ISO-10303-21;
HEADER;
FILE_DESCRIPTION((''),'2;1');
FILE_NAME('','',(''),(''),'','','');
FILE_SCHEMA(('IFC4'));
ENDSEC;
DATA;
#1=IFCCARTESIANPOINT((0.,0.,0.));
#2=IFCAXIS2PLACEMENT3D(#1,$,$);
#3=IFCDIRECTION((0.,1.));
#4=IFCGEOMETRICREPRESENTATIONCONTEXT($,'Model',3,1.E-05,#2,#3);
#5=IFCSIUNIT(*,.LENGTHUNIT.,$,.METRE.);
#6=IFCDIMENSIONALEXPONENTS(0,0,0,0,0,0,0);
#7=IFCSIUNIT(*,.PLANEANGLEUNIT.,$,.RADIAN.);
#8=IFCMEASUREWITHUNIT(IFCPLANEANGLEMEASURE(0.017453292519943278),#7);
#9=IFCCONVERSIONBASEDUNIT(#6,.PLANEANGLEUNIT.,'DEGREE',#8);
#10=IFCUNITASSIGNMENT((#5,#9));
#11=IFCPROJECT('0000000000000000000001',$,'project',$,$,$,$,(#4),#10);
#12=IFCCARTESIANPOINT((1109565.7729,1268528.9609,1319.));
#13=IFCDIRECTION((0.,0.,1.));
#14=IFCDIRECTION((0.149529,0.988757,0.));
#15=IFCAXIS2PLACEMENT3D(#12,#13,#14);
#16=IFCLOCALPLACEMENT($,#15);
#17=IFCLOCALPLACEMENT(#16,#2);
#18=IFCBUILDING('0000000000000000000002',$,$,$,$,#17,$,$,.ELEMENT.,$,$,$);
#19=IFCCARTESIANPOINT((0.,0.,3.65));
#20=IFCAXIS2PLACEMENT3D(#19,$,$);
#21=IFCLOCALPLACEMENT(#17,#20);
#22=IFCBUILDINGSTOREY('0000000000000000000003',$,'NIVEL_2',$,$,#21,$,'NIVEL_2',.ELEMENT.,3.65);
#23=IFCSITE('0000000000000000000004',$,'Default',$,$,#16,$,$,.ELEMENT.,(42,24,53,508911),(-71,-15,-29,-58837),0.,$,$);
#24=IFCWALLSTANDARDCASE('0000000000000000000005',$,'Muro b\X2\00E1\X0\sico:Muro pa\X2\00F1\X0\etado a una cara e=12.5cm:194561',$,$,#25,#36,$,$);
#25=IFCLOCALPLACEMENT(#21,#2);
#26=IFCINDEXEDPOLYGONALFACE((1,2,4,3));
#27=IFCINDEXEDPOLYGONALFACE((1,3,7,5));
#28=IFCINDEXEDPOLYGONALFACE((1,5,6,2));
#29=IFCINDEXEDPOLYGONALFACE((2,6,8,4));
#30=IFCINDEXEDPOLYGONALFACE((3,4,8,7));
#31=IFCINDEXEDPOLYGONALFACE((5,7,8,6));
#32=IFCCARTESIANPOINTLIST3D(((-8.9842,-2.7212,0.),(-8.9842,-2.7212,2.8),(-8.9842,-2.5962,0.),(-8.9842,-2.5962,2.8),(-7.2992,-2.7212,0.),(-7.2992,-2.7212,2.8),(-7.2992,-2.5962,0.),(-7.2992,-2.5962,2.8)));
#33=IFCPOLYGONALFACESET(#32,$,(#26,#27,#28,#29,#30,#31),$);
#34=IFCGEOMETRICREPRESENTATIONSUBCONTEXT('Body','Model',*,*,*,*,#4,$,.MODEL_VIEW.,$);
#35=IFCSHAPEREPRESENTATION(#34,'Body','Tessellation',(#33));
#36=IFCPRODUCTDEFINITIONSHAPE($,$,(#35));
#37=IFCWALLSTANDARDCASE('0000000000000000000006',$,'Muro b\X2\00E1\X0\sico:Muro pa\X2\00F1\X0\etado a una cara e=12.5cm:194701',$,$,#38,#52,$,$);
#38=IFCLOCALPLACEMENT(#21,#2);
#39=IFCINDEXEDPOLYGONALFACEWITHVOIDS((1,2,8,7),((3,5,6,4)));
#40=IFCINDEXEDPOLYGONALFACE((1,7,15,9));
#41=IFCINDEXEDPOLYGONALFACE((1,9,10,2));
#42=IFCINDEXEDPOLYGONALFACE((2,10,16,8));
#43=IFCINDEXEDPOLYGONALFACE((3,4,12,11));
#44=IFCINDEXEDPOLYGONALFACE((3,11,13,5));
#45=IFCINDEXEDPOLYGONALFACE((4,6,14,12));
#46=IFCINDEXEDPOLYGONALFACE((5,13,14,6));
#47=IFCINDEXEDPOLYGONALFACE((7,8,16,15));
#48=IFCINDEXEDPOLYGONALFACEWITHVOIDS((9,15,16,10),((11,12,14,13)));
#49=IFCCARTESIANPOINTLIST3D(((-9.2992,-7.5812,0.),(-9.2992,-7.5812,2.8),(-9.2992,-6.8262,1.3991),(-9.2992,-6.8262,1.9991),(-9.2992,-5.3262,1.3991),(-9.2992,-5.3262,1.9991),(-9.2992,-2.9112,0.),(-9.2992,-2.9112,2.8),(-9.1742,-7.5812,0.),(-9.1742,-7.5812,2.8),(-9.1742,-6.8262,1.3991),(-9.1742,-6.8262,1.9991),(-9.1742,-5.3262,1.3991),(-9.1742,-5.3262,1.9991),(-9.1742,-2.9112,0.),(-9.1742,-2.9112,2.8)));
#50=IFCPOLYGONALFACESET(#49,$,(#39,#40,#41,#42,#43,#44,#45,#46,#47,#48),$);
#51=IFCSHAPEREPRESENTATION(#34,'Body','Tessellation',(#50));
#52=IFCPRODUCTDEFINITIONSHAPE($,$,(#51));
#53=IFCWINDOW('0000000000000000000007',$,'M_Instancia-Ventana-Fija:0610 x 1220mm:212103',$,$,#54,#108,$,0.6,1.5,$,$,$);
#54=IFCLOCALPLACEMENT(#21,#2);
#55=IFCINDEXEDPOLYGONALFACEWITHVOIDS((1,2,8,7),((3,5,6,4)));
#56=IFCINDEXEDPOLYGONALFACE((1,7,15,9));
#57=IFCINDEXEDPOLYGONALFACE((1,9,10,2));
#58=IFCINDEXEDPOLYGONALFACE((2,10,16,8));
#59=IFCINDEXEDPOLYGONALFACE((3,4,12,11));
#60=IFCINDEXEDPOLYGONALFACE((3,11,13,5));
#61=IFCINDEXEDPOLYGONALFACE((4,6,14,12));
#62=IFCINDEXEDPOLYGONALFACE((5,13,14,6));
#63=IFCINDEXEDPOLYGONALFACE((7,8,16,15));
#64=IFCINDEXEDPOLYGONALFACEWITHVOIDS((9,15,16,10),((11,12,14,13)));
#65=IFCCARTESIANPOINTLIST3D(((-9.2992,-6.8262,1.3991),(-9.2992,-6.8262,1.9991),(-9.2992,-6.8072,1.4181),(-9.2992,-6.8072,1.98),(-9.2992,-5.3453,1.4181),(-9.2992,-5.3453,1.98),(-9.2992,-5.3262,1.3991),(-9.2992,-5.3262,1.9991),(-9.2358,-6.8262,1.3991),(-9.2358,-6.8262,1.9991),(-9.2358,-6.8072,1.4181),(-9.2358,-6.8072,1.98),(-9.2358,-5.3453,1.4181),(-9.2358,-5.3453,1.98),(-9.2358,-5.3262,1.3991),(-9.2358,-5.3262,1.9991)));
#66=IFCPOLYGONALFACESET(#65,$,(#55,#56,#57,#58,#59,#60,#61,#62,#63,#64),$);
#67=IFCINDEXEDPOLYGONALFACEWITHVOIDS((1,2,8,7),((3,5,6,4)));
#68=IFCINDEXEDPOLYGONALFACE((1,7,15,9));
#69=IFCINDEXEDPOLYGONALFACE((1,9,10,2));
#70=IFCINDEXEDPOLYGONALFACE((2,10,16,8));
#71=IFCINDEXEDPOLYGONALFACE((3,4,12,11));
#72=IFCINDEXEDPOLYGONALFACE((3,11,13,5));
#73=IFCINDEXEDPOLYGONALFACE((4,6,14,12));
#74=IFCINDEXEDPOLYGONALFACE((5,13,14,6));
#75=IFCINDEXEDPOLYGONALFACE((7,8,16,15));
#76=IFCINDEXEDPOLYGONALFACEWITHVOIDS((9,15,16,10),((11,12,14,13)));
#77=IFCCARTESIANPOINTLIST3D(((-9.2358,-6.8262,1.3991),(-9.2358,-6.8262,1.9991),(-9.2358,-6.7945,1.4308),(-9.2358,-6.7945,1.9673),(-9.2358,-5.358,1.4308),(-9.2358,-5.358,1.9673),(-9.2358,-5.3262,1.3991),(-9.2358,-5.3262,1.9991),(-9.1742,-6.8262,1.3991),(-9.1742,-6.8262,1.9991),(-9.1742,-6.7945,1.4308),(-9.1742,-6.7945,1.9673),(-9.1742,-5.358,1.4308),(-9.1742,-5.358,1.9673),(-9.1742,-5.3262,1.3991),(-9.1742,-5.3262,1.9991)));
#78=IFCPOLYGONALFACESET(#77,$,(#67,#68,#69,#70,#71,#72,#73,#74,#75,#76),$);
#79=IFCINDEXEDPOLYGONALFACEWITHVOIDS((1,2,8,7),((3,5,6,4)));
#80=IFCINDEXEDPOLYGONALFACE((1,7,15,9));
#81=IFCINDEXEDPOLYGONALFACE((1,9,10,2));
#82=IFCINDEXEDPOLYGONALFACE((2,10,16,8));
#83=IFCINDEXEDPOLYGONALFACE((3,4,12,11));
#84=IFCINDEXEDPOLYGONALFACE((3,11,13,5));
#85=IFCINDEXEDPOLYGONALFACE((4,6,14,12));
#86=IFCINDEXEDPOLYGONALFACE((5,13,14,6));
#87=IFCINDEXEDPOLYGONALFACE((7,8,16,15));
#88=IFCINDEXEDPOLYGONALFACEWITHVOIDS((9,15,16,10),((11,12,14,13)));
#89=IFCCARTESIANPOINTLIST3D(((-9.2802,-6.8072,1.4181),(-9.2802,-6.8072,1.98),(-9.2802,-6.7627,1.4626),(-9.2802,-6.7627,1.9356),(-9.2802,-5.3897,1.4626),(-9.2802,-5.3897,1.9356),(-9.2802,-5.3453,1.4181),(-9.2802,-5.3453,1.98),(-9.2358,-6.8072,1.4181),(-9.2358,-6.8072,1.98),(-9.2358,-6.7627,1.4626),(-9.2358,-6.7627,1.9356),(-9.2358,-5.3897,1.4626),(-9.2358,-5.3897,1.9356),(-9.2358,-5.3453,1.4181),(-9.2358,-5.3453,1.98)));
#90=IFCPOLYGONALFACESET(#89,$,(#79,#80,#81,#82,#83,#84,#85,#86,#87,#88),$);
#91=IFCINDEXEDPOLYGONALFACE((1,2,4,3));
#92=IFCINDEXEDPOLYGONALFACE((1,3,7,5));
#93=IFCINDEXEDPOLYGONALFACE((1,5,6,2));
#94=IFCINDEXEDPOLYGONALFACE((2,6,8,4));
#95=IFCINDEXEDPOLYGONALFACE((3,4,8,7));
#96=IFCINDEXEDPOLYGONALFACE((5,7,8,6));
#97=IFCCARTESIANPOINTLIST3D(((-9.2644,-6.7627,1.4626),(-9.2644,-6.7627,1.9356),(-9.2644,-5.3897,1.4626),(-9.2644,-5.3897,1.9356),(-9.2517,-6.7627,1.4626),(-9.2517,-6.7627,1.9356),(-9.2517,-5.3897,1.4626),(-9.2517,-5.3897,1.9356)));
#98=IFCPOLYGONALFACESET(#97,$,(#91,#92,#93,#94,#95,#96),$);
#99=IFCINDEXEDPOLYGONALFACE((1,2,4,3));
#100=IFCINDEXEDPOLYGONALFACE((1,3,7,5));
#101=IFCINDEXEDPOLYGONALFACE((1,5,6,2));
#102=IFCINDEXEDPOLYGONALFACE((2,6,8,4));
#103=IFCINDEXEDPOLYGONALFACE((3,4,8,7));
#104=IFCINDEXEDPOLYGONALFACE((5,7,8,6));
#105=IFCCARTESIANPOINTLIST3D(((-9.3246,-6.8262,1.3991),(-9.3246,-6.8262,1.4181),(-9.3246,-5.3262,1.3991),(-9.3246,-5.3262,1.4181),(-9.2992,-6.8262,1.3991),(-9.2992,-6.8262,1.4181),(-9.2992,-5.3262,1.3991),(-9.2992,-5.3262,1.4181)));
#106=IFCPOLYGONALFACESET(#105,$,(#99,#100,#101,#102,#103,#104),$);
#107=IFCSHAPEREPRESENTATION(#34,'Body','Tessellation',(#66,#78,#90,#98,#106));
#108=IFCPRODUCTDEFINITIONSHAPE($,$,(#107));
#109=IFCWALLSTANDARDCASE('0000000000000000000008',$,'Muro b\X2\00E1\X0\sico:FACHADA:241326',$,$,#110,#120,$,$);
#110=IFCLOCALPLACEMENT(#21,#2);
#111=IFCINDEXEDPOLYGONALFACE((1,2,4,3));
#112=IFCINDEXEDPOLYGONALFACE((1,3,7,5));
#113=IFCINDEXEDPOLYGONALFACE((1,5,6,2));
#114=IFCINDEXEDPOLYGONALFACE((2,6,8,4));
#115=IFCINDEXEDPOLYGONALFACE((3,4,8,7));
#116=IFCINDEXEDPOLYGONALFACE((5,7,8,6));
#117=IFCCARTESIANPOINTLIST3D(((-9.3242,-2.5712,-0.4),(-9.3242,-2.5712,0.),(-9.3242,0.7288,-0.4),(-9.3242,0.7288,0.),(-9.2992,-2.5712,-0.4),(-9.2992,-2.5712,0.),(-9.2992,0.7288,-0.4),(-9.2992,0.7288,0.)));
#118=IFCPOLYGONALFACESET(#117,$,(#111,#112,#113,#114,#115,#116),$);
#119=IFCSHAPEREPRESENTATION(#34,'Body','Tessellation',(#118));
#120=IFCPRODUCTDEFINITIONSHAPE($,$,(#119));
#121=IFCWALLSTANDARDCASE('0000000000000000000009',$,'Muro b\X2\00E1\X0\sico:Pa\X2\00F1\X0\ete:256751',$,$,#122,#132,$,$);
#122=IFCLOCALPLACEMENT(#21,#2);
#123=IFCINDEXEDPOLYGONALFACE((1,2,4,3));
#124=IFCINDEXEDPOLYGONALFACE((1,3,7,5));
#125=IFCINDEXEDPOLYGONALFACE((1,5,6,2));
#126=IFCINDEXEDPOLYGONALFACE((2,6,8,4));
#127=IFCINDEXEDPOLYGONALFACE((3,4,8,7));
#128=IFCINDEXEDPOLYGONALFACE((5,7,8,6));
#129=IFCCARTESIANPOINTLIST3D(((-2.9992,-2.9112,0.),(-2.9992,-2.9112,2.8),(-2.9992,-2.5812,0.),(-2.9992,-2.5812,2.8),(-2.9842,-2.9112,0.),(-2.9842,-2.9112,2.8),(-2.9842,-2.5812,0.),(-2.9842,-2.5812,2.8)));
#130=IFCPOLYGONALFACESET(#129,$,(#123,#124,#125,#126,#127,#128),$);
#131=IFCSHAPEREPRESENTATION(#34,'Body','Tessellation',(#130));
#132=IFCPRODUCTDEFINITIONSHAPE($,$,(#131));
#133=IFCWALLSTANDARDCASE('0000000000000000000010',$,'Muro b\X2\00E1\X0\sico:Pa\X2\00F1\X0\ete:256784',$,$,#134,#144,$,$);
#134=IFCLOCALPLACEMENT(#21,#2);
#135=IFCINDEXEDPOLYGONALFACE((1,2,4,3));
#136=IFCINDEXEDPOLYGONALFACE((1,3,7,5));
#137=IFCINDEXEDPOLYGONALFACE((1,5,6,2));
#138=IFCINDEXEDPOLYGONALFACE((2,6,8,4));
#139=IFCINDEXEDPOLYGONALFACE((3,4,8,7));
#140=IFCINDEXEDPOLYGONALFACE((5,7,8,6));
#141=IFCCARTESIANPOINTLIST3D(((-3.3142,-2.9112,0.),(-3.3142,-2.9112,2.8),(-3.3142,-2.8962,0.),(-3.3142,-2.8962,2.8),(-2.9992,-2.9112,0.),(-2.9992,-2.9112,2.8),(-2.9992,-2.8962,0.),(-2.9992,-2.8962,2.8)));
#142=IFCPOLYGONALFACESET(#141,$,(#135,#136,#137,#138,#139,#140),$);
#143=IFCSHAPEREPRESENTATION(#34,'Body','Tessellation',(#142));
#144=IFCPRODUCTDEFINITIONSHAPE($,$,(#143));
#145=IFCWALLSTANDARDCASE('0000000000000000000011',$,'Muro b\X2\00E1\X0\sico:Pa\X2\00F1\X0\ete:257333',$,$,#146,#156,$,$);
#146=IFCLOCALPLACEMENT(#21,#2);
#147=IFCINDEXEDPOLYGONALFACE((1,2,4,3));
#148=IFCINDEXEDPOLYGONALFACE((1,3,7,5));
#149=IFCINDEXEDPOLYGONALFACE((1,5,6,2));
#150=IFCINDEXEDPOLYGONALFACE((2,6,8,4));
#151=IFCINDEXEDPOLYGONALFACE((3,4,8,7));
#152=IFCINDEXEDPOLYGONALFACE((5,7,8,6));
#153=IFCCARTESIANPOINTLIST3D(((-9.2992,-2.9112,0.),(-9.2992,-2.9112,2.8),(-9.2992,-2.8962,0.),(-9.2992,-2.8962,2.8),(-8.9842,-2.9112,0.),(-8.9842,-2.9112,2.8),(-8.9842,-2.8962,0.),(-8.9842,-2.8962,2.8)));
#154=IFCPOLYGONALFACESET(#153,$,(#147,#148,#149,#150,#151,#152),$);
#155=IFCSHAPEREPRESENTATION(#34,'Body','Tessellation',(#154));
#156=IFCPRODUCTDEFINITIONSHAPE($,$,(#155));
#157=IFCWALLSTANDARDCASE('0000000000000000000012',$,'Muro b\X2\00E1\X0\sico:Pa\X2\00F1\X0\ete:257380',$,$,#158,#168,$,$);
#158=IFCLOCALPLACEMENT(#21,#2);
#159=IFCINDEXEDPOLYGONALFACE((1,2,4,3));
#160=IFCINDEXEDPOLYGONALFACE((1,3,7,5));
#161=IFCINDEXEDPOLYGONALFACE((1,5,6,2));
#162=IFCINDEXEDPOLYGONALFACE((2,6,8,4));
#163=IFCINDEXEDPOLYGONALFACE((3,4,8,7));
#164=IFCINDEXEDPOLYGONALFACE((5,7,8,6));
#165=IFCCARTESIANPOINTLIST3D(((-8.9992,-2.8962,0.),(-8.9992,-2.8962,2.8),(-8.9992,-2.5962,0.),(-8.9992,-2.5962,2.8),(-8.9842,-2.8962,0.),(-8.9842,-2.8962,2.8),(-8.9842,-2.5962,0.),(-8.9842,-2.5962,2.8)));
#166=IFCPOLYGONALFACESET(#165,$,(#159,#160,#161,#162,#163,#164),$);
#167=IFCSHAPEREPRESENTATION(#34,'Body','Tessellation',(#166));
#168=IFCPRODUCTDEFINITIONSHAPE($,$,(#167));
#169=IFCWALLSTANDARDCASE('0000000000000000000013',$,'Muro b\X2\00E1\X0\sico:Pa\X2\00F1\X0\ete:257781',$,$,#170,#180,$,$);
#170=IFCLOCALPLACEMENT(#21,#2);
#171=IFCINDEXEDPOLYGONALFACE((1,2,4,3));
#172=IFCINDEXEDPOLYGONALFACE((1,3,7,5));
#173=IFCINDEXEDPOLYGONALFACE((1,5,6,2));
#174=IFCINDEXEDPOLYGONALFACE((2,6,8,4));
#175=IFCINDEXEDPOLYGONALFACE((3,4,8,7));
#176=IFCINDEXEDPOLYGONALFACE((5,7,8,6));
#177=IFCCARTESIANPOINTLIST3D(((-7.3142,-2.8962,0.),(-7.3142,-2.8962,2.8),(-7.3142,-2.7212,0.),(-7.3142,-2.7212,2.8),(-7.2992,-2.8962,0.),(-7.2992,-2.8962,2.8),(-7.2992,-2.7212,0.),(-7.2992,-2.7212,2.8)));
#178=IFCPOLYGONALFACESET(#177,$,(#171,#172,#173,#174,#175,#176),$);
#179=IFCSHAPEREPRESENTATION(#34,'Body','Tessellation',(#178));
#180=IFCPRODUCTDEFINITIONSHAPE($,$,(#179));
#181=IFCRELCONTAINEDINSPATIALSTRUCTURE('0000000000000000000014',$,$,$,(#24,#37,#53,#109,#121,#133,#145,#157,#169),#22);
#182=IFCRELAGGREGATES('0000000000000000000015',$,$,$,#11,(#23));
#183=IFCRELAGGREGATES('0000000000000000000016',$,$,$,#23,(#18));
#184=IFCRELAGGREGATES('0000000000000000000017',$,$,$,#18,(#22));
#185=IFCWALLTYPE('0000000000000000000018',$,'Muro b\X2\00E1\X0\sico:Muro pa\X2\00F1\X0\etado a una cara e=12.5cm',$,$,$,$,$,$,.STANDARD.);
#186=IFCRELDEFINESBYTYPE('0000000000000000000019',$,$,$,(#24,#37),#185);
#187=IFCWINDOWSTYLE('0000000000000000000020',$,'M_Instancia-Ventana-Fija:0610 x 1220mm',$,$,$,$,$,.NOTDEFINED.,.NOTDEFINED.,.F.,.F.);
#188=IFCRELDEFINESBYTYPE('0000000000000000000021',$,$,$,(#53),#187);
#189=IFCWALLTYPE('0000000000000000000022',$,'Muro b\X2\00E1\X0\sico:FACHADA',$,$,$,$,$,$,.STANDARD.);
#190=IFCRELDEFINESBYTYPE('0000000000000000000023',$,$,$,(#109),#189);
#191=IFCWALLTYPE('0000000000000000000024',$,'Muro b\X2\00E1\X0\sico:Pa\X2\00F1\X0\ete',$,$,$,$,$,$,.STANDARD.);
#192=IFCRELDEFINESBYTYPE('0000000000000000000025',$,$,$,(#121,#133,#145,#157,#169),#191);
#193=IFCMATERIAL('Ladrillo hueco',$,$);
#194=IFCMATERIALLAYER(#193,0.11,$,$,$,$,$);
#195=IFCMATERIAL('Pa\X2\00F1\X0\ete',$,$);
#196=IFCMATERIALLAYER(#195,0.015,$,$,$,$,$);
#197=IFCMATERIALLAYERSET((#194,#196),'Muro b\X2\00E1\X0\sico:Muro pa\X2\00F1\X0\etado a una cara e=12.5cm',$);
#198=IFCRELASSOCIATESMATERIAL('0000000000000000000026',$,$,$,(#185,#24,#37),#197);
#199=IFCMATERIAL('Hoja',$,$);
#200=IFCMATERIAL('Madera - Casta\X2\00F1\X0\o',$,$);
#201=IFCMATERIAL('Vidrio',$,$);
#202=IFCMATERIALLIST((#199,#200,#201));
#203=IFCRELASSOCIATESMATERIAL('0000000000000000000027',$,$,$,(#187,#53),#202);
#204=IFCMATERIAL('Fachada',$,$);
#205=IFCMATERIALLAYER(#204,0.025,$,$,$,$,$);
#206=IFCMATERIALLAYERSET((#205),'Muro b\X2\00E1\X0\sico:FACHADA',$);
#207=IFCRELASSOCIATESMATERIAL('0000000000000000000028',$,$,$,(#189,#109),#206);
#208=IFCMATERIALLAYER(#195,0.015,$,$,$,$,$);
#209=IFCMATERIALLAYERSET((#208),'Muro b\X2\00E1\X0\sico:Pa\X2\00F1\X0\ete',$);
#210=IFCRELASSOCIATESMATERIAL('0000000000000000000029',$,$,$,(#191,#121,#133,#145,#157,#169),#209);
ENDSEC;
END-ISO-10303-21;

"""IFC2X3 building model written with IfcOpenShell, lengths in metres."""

from ifc_helpers import new_model, entity, si_unit, converted_unit, direction, frame, frame_2d, origin, origin_2d_with_axis, place, context, subcontext, project, spatial, polyline, rectangle, outline, extrude, source, transform, mapped, material, material_list, layer, layer_set, layer_usage, type_object, type_shapes, element, fill, save


model = new_model("IFC2X3")

# Units and contexts
model_context = context("Model", 3, precision=1e-05, world=origin(), true_north=direction((0.0, 1.0)))
body_context = subcontext(model_context, "Body", "Model", "MODEL_VIEW")
ifc_project = project(units=[si_unit("LENGTHUNIT", "METRE"), converted_unit("PLANEANGLEUNIT", "DEGREE", entity("IfcPlaneAngleMeasure", 0.017453292519943278), si_unit("PLANEANGLEUNIT", "RADIAN"), dimensions=[0, 0, 0, 0, 0, 0, 0])], contexts=[model_context])

# Site, building, storey
site_placement = place(None, frame((1109565.7729, 1268528.9609, 1319.0), z_axis=(0.0, 0.0, 1.0), x_axis=(0.149529, 0.988757, 0.0)))
site = spatial("IfcSite", under=ifc_project, at=site_placement, Name="Default", CompositionType="ELEMENT", RefLatitude=(42, 24, 53, 508911), RefLongitude=(-71, -15, -29, -58837), RefElevation=0.0)
building_placement = place(site_placement, origin())
building = spatial("IfcBuilding", under=site, at=building_placement, CompositionType="ELEMENT")
storey_placement = place(building_placement, frame((0.0, 0.0, 3.65)))
storey = spatial("IfcBuildingStorey", under=building, at=storey_placement, Name="NIVEL_2", LongName="NIVEL_2", CompositionType="ELEMENT", Elevation=3.65)

# Shared definitions
ifc_material_1 = material(Name="Pañete")
ifc_material_2 = material(Name="Ladrillo hueco")

# Shared definitions
ifc_material_3 = material(Name="Vidrio")

# Wall
ifc_layer_1 = layer(ifc_material_2, 0.11)
ifc_layer_2 = layer(ifc_material_1, 0.015)
ifc_layer_set_1 = layer_set([ifc_layer_1, ifc_layer_2], Name="Muro básico:Muro pañetado a una cara e=12.5cm")
ifc_layer_usage_1 = layer_usage(ifc_layer_set_1, "AXIS2", "POSITIVE", -0.0625)
wall_type_1 = type_object("IfcWallType", Name="Muro básico:Muro pañetado a una cara e=12.5cm", PredefinedType="STANDARD", material=ifc_layer_set_1)
wall_1_placement = place(storey_placement, frame((-7.2992, -2.6587, 0.0), z_axis=(0.0, 0.0, 1.0), x_axis=(-1.0, 0.0, 0.0)))
element("IfcWallStandardCase", 1, at=wall_1_placement, inside=storey, type_object=wall_type_1, material=ifc_layer_usage_1, Name="Muro básico:Muro pañetado a una cara e=12.5cm:194561", context=body_context, shape_type="SweptSolid", body=[
    extrude(rectangle(XDim=1.685, YDim=0.125, at=frame_2d((0.8425, 0.0), x_axis=(-1.0, 0.0))), origin(), (0.0, 0.0, 1.0), 2.8),
])

# Wall, opening, window
ifc_layer_usage_2 = layer_usage(ifc_layer_set_1, "AXIS2", "POSITIVE", -0.0625)
wall_2_placement = place(storey_placement, frame((-9.2367, -2.9112, 0.0), z_axis=(0.0, 0.0, 1.0), x_axis=(0.0, -1.0, 0.0)))
wall_2 = element("IfcWallStandardCase", 2, at=wall_2_placement, inside=storey, type_object=wall_type_1, material=ifc_layer_usage_2, Name="Muro básico:Muro pañetado a una cara e=12.5cm:194701", context=body_context, shape_type="SweptSolid", body=[
    extrude(rectangle(XDim=4.67, YDim=0.125, at=frame_2d((2.335, 0.0), x_axis=(-1.0, 0.0))), origin(), (0.0, 0.0, 1.0), 2.8),
])
opening_1_placement = place(wall_2_placement, frame((3.915, 0.0625, 1.3991)))
opening_1 = element("IfcOpeningElement", 3, at=opening_1_placement, cuts=wall_2, ObjectType="Opening", context=body_context, shape_type="SweptSolid", body=[
    extrude(rectangle(XDim=0.6, YDim=1.5, at=frame_2d((0.3, 0.75), x_axis=(-1.0, 0.0))), frame((0.0, 0.0, 0.0), z_axis=(0.0, -1.0, 0.0), x_axis=(0.0, 0.0, 1.0)), (0.0, 0.0, 1.0), 0.125),
])
ifc_material_4 = material(Name="Hoja")
ifc_material_5 = material(Name="Madera - Castaño")
ifc_material_list_1 = material_list([ifc_material_4, ifc_material_5, ifc_material_3])
window_style = type_object("IfcWindowStyle", Name="M_Instancia-Ventana-Fija:0610 x 1220mm", ConstructionType="NOTDEFINED", OperationType="NOTDEFINED", ParameterTakesPrecedence=False, Sizeable=False, material=ifc_material_list_1)
shared_shape_1 = source(origin(), body_context, "Body", "SweptSolid", [
    extrude(outline(polyline([(-0.3, -0.75), (0.3, -0.75), (0.3, 0.75), (-0.3, 0.75), (-0.3, -0.75)]), holes=[polyline([(-0.2809, -0.7309), (-0.2809, 0.731), (0.281, 0.731), (0.281, -0.7309), (-0.2809, -0.7309)])]), frame((0.75, 0.0616, 0.3), z_axis=(0.0, 1.0, 0.0), x_axis=(0.0, 0.0, -1.0)), (0.0, 0.0, 1.0), 0.0635),
    extrude(outline(polyline([(-0.75, -0.3), (0.75, -0.3), (0.75, 0.3), (-0.75, 0.3), (-0.75, -0.3)]), holes=[polyline([(-0.7183, -0.2682), (-0.7183, 0.2683), (0.7182, 0.2683), (0.7182, -0.2682), (-0.7183, -0.2682)])]), frame((0.75, 0.0, 0.3), z_axis=(0.0, 1.0, 0.0), x_axis=(1.0, 0.0, 0.0)), (0.0, 0.0, 1.0), 0.0616),
    extrude(outline(polyline([(-0.7309, -0.281), (0.7309, -0.281), (0.7309, 0.281), (-0.7309, 0.281), (-0.7309, -0.281)]), holes=[polyline([(-0.6865, -0.2365), (-0.6865, 0.2365), (0.6865, 0.2365), (0.6865, -0.2365), (-0.6865, -0.2365)])]), frame((0.75, 0.0616, 0.3), z_axis=(0.0, 1.0, 0.0), x_axis=(1.0, 0.0, 0.0)), (0.0, 0.0, 1.0), 0.0444),
    extrude(rectangle(XDim=0.0127, YDim=1.373, at=origin_2d_with_axis()), frame((0.75, 0.0838, 0.0635), z_axis=(0.0, 0.0, 1.0), x_axis=(0.0, 1.0, 0.0)), (0.0, 0.0, 1.0), 0.473),
    extrude(rectangle(XDim=0.0254, YDim=1.5, at=origin_2d_with_axis()), frame((0.75, 0.1377, 0.0), z_axis=(0.0, 0.0, 1.0), x_axis=(0.0, -1.0, 0.0)), (0.0, 0.0, 1.0), 0.019),
])
type_shapes(window_style, [shared_shape_1])
window_placement = place(opening_1_placement, frame((0.0, 0.0, 0.0), z_axis=(0.0, 0.0, 1.0), x_axis=(-1.0, 0.0, 0.0)))
window = element("IfcWindow", 4, at=window_placement, inside=storey, type_object=window_style, material=ifc_material_list_1, Name="M_Instancia-Ventana-Fija:0610 x 1220mm:212103", OverallHeight=0.6, OverallWidth=1.5, context=body_context, shape_type="MappedRepresentation", body=[
    mapped(shared_shape_1, transform((0.0, 0.0, 0.0), scale=1.0)),
])
fill(opening_1, window)

# Walls
ifc_material_6 = material(Name="Fachada")
ifc_layer_3 = layer(ifc_material_6, 0.025)
ifc_layer_set_2 = layer_set([ifc_layer_3], Name="Muro básico:FACHADA")
ifc_layer_usage_3 = layer_usage(ifc_layer_set_2, "AXIS2", "NEGATIVE", 0.0125)
wall_type_2 = type_object("IfcWallType", Name="Muro básico:FACHADA", PredefinedType="STANDARD", material=ifc_layer_set_2)
wall_3_placement = place(storey_placement, frame((-9.3117, -2.5712, -0.4), z_axis=(0.0, 0.0, 1.0), x_axis=(0.0, 1.0, 0.0)))
element("IfcWallStandardCase", 5, at=wall_3_placement, inside=storey, type_object=wall_type_2, material=ifc_layer_usage_3, Name="Muro básico:FACHADA:241326", context=body_context, shape_type="SweptSolid", body=[
    extrude(rectangle(XDim=3.3, YDim=0.025, at=frame_2d((1.65, 0.0), x_axis=(-1.0, 0.0))), origin(), (0.0, 0.0, 1.0), 0.4),
])
ifc_layer_4 = layer(ifc_material_1, 0.015)
ifc_layer_set_3 = layer_set([ifc_layer_4], Name="Muro básico:Pañete")
ifc_layer_usage_4 = layer_usage(ifc_layer_set_3, "AXIS2", "NEGATIVE", 0.0075)
wall_type_3 = type_object("IfcWallType", Name="Muro básico:Pañete", PredefinedType="STANDARD", material=ifc_layer_set_3)
wall_4_placement = place(storey_placement, frame((-2.9917, -2.5812, 0.0), z_axis=(0.0, 0.0, 1.0), x_axis=(0.0, -1.0, 0.0)))
element("IfcWallStandardCase", 6, at=wall_4_placement, inside=storey, type_object=wall_type_3, material=ifc_layer_usage_4, Name="Muro básico:Pañete:256751", context=body_context, shape_type="SweptSolid", body=[
    extrude(rectangle(XDim=0.33, YDim=0.015, at=frame_2d((0.165, 0.0), x_axis=(-1.0, 0.0))), origin(), (0.0, 0.0, 1.0), 2.8),
])
ifc_layer_usage_5 = layer_usage(ifc_layer_set_3, "AXIS2", "NEGATIVE", 0.0075)
wall_5_placement = place(storey_placement, frame((-2.9992, -2.9037, 0.0), z_axis=(0.0, 0.0, 1.0), x_axis=(-1.0, 0.0, 0.0)))
element("IfcWallStandardCase", 7, at=wall_5_placement, inside=storey, type_object=wall_type_3, material=ifc_layer_usage_5, Name="Muro básico:Pañete:256784", context=body_context, shape_type="SweptSolid", body=[
    extrude(rectangle(XDim=0.315, YDim=0.015, at=frame_2d((0.1575, 0.0), x_axis=(-1.0, 0.0))), origin(), (0.0, 0.0, 1.0), 2.8),
])
ifc_layer_usage_6 = layer_usage(ifc_layer_set_3, "AXIS2", "POSITIVE", -0.0075)
wall_6_placement = place(storey_placement, frame((-9.2992, -2.9037, 0.0)))
element("IfcWallStandardCase", 8, at=wall_6_placement, inside=storey, type_object=wall_type_3, material=ifc_layer_usage_6, Name="Muro básico:Pañete:257333", context=body_context, shape_type="SweptSolid", body=[
    extrude(rectangle(XDim=0.315, YDim=0.015, at=frame_2d((0.1575, 0.0), x_axis=(-1.0, 0.0))), origin(), (0.0, 0.0, 1.0), 2.8),
])
ifc_layer_usage_7 = layer_usage(ifc_layer_set_3, "AXIS2", "POSITIVE", -0.0075)
wall_7_placement = place(storey_placement, frame((-8.9917, -2.8962, 0.0), z_axis=(0.0, 0.0, 1.0), x_axis=(0.0, 1.0, 0.0)))
element("IfcWallStandardCase", 9, at=wall_7_placement, inside=storey, type_object=wall_type_3, material=ifc_layer_usage_7, Name="Muro básico:Pañete:257380", context=body_context, shape_type="SweptSolid", body=[
    extrude(rectangle(XDim=0.3, YDim=0.015, at=frame_2d((0.15, 0.0), x_axis=(-1.0, 0.0))), origin(), (0.0, 0.0, 1.0), 2.8),
])
ifc_layer_usage_8 = layer_usage(ifc_layer_set_3, "AXIS2", "NEGATIVE", 0.0075)
wall_8_placement = place(storey_placement, frame((-7.3067, -2.8962, 0.0), z_axis=(0.0, 0.0, 1.0), x_axis=(0.0, 1.0, 0.0)))
element("IfcWallStandardCase", 10, at=wall_8_placement, inside=storey, type_object=wall_type_3, material=ifc_layer_usage_8, Name="Muro básico:Pañete:257781", context=body_context, shape_type="SweptSolid", body=[
    extrude(rectangle(XDim=0.175, YDim=0.015, at=frame_2d((0.0875, 0.0), x_axis=(-1.0, 0.0))), origin(), (0.0, 0.0, 1.0), 2.8),
])

save(model, "model.ifc")
